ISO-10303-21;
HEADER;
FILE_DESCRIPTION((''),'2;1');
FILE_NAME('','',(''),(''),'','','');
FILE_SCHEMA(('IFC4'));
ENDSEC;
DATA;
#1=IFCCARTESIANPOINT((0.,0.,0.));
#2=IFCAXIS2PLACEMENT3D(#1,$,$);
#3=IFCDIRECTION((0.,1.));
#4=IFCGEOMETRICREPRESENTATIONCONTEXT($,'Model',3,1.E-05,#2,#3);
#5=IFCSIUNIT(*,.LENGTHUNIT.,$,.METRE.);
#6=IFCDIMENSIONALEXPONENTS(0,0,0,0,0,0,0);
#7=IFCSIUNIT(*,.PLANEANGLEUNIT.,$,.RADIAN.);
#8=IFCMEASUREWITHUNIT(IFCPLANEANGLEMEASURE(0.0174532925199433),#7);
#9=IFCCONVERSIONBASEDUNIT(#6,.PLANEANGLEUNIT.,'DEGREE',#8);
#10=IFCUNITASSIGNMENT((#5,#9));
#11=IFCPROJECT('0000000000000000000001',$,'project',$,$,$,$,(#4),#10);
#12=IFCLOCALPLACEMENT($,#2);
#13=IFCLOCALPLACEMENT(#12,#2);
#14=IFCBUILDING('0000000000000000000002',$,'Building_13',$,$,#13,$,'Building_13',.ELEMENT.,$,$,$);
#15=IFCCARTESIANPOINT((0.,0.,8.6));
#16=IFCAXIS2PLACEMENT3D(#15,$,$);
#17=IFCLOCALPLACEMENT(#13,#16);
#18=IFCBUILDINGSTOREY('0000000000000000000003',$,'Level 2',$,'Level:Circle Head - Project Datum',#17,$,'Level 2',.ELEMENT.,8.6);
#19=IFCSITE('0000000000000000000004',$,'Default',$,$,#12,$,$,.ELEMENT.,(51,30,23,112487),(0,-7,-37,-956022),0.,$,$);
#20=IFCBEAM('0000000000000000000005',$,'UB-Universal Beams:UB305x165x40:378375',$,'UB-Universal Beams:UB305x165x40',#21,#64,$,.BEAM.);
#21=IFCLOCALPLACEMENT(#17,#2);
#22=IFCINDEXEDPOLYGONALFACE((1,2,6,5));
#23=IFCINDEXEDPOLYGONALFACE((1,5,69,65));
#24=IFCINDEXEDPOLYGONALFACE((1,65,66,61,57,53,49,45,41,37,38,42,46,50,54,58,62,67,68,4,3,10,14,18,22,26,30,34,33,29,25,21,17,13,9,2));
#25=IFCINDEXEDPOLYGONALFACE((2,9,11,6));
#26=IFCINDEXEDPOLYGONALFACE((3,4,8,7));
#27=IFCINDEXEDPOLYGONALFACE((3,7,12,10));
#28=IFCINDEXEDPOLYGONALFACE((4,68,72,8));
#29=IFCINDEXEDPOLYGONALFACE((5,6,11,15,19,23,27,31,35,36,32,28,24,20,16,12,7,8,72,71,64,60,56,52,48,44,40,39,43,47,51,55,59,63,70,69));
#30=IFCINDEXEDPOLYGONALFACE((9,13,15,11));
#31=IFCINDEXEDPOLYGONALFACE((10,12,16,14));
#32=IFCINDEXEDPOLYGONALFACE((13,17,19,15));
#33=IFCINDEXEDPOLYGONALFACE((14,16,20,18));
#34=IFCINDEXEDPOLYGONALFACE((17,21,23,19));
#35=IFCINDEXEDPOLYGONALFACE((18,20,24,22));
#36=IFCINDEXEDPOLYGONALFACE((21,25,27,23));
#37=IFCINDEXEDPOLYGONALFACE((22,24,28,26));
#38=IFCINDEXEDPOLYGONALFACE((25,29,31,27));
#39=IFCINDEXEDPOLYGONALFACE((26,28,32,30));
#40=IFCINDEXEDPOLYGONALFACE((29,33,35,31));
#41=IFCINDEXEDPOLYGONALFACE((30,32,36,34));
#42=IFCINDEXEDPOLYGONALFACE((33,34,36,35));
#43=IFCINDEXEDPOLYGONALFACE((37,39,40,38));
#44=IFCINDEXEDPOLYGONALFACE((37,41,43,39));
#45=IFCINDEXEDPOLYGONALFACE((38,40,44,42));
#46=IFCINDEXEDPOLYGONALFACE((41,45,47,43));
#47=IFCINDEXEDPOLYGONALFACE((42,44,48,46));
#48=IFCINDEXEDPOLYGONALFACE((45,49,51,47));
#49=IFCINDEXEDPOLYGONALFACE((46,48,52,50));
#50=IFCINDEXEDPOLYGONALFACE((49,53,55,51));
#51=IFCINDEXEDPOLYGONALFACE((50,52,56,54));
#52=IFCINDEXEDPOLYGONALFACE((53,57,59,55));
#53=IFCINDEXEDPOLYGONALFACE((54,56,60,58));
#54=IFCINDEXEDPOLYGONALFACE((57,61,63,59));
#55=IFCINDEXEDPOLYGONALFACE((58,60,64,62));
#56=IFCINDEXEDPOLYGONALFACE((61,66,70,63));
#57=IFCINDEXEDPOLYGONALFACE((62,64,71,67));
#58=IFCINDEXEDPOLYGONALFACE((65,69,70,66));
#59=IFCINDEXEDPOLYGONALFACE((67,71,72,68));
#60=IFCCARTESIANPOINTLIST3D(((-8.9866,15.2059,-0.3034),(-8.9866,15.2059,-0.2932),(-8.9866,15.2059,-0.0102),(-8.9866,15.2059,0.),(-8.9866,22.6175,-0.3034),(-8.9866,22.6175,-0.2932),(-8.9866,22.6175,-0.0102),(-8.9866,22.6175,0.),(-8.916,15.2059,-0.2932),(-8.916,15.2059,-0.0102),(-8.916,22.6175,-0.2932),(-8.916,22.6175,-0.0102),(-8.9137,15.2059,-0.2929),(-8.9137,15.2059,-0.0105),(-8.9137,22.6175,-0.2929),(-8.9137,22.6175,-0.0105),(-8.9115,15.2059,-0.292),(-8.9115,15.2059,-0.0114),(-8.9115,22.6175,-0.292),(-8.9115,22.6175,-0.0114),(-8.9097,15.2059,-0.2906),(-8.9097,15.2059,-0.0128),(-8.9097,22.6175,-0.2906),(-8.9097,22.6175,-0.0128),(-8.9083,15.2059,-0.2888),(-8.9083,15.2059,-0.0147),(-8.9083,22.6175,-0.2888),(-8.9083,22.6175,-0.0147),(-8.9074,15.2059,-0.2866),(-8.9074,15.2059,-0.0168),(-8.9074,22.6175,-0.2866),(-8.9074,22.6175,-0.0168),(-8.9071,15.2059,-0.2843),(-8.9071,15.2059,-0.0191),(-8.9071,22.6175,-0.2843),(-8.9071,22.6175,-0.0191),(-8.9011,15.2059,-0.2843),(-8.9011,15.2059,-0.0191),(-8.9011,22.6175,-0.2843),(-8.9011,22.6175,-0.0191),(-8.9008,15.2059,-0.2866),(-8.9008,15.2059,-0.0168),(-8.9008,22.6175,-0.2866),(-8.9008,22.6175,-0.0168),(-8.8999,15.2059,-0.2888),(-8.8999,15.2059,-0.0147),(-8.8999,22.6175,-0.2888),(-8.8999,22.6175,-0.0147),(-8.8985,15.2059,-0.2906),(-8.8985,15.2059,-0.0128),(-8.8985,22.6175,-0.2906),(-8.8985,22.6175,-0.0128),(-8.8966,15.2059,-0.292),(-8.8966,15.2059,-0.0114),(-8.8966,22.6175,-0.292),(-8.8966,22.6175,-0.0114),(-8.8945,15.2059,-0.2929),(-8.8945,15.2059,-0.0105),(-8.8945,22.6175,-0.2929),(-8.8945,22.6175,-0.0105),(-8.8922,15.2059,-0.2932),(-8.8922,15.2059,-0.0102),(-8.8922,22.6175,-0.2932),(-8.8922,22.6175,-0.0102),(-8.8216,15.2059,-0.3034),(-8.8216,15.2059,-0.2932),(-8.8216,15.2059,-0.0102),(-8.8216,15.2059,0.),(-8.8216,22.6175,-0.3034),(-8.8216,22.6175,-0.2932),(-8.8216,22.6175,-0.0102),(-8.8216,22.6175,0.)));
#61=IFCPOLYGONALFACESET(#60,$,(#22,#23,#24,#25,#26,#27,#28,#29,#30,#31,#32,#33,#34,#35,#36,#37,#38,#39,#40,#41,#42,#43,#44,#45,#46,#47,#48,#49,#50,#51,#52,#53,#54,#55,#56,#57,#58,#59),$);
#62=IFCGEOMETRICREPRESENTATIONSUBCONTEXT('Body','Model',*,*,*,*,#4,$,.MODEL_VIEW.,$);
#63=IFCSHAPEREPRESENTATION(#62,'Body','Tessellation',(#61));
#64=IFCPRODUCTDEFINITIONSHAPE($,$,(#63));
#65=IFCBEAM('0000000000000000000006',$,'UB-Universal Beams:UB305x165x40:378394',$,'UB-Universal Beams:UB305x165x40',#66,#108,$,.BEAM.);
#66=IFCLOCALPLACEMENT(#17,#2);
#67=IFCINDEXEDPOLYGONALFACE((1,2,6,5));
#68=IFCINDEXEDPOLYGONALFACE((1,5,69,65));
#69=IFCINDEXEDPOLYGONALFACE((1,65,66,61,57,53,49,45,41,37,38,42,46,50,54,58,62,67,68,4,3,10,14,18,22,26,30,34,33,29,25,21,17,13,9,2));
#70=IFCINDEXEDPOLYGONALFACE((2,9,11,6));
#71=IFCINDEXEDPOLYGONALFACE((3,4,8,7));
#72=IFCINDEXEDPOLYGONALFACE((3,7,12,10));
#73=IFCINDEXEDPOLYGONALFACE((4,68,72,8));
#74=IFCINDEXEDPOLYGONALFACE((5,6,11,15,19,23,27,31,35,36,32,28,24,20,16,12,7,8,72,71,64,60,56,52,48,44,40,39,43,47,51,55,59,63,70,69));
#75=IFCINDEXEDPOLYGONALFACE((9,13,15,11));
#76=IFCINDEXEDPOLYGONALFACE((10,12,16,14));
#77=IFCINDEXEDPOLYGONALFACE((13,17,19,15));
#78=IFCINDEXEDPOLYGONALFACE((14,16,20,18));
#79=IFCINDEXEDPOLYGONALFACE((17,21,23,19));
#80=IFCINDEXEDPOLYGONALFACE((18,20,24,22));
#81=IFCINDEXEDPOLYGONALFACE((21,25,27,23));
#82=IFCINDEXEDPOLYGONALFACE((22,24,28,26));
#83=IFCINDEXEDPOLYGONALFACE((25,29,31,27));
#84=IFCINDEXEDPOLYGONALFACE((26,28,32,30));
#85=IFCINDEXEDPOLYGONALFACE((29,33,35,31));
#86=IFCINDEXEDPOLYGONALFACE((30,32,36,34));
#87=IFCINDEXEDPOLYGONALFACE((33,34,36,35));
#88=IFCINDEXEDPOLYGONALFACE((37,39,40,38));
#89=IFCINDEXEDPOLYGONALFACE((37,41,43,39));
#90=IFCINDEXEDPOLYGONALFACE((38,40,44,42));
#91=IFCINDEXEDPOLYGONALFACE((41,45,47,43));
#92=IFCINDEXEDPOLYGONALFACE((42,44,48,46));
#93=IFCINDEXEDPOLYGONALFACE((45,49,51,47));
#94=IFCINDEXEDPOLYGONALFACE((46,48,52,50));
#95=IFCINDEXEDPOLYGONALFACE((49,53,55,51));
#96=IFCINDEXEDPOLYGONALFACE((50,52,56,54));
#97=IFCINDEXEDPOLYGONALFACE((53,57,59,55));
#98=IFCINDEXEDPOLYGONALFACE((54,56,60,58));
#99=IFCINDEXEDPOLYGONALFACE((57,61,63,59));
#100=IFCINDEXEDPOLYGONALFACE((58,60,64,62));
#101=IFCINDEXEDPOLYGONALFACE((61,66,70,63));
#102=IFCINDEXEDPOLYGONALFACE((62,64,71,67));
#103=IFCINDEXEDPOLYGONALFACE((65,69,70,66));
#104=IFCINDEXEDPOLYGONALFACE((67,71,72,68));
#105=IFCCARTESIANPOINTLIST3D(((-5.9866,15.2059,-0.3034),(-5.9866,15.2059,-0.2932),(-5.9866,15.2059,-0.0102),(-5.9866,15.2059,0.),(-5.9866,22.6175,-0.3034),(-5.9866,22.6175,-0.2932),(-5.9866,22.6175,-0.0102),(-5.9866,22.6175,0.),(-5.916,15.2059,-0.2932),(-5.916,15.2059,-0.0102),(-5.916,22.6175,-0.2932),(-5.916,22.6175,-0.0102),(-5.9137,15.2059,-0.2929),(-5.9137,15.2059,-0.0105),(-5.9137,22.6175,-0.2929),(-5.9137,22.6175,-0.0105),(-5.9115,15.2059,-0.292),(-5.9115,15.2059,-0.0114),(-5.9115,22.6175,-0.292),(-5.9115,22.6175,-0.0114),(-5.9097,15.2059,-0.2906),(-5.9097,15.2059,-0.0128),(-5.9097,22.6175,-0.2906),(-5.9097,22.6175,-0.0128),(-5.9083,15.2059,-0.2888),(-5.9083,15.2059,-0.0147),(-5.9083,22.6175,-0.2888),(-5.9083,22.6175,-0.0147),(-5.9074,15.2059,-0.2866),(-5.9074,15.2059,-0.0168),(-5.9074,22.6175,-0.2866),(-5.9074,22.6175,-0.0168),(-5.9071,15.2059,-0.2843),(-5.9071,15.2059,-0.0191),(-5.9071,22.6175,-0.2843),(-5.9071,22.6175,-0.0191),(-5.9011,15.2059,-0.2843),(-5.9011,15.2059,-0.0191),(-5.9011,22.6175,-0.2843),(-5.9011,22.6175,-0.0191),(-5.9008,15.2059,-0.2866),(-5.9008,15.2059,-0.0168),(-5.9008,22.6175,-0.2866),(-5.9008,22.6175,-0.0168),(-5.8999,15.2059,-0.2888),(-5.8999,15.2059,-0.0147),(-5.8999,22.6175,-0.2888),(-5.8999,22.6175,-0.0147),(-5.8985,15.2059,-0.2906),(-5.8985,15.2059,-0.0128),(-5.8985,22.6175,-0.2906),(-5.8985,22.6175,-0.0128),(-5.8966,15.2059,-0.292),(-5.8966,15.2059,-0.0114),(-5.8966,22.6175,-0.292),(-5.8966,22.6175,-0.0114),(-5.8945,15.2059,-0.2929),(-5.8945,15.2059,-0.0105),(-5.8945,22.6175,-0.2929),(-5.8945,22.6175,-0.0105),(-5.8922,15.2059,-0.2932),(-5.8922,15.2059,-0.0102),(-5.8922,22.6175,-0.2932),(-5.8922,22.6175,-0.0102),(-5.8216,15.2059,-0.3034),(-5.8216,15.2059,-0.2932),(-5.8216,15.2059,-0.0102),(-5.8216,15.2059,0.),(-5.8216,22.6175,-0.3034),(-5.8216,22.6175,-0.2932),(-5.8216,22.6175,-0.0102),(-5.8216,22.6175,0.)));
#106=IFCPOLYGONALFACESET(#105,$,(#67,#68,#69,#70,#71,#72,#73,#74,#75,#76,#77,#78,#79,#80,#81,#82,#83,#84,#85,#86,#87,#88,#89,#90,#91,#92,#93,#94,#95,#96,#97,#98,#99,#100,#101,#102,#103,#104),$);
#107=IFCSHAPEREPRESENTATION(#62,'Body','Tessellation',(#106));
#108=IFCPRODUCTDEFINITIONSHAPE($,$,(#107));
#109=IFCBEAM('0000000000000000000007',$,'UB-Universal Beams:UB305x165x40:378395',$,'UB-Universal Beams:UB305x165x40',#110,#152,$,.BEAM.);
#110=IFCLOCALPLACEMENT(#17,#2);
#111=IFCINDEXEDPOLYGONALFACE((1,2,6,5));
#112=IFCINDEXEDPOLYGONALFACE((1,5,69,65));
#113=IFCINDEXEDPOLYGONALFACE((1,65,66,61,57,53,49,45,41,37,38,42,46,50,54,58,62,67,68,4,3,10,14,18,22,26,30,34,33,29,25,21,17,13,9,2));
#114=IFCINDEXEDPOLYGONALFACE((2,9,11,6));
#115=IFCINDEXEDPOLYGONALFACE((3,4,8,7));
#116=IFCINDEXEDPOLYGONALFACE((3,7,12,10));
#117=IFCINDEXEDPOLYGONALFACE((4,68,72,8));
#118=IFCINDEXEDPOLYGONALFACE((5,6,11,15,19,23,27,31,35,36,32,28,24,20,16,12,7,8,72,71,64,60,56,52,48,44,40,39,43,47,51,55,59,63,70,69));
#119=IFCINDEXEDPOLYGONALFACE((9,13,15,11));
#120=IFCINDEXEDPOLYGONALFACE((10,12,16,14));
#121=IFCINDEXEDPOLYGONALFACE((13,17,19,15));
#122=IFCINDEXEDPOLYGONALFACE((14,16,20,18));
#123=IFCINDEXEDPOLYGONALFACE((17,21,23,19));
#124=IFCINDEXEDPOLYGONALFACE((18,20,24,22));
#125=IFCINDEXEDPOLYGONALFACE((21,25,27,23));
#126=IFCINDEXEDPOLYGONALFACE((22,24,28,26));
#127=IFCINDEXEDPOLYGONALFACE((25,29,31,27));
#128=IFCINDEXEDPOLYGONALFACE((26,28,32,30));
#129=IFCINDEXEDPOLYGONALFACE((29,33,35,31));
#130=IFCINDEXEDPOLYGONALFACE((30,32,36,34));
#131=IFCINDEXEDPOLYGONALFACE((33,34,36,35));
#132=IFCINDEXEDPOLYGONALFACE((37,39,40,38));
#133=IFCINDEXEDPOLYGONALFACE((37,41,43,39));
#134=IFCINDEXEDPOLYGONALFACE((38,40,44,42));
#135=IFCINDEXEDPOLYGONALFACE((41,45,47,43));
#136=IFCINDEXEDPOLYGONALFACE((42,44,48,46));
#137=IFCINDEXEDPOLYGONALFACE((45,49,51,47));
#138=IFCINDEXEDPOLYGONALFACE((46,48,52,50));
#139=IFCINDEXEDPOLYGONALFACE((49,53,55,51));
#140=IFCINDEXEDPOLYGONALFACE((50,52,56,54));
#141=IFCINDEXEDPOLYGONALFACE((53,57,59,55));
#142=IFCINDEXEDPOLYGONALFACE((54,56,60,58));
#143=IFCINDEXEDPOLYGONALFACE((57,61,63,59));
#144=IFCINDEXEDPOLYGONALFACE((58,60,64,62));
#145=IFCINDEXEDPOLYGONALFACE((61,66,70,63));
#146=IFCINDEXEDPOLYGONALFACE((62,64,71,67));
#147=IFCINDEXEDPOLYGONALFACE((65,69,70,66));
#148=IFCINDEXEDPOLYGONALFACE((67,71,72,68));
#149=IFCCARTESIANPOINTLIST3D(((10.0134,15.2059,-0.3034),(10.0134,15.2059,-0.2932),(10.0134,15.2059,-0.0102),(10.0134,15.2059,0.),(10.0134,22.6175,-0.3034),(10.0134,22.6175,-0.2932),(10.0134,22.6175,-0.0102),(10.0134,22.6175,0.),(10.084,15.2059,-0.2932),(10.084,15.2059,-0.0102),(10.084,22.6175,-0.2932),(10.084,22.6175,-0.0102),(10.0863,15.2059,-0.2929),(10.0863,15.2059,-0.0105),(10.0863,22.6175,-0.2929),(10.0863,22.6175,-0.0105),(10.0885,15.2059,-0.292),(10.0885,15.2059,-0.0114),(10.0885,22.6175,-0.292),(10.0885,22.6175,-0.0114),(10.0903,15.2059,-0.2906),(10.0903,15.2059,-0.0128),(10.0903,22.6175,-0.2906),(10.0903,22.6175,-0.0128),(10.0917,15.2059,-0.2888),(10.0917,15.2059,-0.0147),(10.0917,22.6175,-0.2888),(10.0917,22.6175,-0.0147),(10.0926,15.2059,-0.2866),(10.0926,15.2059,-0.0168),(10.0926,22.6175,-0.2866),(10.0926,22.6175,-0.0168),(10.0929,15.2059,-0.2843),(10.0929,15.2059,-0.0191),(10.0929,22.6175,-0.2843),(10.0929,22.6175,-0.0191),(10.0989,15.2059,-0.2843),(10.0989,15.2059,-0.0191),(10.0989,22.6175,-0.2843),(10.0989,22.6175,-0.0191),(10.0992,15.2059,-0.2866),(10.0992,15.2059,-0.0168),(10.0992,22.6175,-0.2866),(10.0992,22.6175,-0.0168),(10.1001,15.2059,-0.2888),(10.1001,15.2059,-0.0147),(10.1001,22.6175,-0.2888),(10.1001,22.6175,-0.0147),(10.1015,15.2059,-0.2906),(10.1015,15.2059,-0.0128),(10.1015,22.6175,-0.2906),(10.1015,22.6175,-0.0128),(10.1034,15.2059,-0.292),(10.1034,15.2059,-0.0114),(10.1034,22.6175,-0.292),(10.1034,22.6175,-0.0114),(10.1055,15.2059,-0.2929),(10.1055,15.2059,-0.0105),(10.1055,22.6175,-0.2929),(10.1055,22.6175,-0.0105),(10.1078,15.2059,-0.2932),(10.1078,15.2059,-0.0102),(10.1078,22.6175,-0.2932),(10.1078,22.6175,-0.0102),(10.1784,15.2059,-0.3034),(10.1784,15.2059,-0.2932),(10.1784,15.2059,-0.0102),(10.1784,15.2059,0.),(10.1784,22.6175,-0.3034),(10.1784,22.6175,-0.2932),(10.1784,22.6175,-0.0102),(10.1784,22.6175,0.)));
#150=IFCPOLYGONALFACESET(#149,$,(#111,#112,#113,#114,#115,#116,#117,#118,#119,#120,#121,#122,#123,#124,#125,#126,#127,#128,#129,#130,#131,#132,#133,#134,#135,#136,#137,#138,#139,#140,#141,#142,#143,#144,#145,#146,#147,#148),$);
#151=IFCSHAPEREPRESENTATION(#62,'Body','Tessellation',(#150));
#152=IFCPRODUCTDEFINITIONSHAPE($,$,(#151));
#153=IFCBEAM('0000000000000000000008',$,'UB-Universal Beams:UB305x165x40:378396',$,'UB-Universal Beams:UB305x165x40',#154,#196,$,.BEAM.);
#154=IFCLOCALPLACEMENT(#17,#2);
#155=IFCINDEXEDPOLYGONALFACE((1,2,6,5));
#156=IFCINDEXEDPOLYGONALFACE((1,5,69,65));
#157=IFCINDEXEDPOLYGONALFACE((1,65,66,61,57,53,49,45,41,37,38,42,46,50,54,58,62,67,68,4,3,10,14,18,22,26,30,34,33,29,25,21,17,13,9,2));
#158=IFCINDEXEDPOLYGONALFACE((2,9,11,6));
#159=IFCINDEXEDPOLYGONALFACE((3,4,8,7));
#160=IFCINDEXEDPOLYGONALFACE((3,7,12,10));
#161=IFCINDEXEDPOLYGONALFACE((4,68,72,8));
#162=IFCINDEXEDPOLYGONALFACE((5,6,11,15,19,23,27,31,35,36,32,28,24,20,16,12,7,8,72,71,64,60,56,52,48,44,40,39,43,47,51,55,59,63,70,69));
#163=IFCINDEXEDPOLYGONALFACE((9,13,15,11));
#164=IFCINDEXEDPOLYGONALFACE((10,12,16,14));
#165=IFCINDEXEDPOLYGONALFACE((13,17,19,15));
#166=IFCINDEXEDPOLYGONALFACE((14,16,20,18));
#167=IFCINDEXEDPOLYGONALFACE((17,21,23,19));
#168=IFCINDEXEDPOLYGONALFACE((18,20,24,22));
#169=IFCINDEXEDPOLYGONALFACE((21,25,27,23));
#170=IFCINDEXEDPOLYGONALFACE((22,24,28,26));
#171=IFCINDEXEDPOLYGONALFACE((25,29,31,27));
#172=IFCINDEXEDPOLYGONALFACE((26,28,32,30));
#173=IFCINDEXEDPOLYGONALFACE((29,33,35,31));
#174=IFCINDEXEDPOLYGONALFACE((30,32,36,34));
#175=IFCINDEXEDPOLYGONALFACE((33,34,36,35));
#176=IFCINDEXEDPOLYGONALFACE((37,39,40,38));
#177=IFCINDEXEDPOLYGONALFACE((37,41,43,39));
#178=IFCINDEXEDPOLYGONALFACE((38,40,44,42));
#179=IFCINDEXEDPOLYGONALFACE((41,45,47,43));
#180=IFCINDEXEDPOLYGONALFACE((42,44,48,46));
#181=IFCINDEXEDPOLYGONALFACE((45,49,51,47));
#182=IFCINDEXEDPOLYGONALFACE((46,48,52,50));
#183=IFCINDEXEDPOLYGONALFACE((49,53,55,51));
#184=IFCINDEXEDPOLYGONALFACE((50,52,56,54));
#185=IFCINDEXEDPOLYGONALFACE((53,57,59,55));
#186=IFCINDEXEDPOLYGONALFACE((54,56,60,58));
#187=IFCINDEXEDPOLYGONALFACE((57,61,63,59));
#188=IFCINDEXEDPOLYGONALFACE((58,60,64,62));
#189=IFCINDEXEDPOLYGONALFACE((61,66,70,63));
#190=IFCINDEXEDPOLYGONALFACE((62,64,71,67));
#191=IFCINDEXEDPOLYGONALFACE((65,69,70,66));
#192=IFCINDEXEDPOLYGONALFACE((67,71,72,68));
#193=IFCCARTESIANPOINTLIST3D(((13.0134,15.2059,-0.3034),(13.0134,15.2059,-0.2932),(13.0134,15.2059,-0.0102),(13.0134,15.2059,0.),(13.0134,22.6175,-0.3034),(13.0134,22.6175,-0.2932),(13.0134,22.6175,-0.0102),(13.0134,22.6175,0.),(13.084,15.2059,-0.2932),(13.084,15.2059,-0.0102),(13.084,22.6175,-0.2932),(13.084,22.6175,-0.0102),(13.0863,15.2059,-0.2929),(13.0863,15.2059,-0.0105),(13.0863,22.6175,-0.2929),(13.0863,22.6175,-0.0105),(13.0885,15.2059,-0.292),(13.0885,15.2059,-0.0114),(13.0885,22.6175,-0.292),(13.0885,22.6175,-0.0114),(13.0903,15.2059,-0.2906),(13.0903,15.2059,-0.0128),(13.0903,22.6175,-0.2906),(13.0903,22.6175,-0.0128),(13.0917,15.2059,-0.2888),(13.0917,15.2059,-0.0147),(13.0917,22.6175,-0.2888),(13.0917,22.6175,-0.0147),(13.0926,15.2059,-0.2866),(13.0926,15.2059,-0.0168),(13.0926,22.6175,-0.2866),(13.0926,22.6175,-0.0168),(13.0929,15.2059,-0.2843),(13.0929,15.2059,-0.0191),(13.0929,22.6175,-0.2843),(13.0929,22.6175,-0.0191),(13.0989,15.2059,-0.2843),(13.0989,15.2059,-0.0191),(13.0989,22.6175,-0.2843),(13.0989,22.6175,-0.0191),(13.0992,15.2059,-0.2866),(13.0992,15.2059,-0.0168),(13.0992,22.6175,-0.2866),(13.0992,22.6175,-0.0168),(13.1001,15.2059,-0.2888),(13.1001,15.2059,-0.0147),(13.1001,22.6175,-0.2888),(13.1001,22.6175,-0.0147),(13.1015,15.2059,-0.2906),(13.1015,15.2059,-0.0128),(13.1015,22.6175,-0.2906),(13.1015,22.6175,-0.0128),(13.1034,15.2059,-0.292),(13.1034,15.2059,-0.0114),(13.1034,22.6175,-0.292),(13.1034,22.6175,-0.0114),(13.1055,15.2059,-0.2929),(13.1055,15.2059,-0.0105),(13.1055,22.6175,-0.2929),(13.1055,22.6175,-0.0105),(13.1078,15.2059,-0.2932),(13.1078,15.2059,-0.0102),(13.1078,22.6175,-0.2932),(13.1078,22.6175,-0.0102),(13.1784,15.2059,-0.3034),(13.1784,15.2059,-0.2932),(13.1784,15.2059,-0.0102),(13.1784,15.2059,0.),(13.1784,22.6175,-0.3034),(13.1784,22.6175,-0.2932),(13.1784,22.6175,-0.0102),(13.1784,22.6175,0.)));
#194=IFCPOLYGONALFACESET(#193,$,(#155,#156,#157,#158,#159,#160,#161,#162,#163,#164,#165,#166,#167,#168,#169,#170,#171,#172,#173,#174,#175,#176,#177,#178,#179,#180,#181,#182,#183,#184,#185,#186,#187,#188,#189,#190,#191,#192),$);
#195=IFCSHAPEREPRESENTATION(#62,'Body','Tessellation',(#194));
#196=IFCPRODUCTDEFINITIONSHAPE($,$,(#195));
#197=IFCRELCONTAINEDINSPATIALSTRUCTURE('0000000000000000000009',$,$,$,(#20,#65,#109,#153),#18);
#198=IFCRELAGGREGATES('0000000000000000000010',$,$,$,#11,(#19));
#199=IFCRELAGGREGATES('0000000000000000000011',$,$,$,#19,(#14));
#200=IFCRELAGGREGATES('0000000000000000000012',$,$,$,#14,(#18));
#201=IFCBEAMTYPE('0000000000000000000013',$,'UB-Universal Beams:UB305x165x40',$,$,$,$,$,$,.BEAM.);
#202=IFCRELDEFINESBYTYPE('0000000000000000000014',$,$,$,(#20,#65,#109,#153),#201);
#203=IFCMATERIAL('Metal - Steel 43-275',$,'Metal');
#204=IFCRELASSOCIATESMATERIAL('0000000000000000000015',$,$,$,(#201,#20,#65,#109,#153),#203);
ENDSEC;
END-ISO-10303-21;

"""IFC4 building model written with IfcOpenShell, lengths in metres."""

from ifc_helpers import new_model, entity, si_unit, converted_unit, direction, frame, origin, place, context, subcontext, project, spatial, line, arc, indexed_curve, outline, extrude, source, transform, mapped, material, type_object, type_shapes, element, save


model = new_model("IFC4")

# Units and contexts
model_context = context("Model", 3, precision=1e-05, world=origin(), true_north=direction((0.0, 1.0)))
body_context = subcontext(model_context, "Body", "Model", "MODEL_VIEW")
ifc_project = project(units=[si_unit("LENGTHUNIT", "METRE"), converted_unit("PLANEANGLEUNIT", "DEGREE", entity("IfcPlaneAngleMeasure", 0.0174532925199433), si_unit("PLANEANGLEUNIT", "RADIAN"), dimensions=[0, 0, 0, 0, 0, 0, 0])], contexts=[model_context])

# Site, building, storey
site_placement = place(None, origin())
site = spatial("IfcSite", under=ifc_project, at=site_placement, Name="Default", CompositionType="ELEMENT", RefLatitude=(51, 30, 23, 112487), RefLongitude=(0, -7, -37, -956022), RefElevation=0.0)
building_placement = place(site_placement, origin())
building = spatial("IfcBuilding", under=site, at=building_placement, Name="Building_13", LongName="Building_13", CompositionType="ELEMENT")
storey_placement = place(building_placement, frame((0.0, 0.0, 8.6)))
storey = spatial("IfcBuildingStorey", under=building, at=storey_placement, Name="Level 2", ObjectType="Level:Circle Head - Project Datum", LongName="Level 2", CompositionType="ELEMENT", Elevation=8.6)

# Beams
ifc_material_1 = material(Name="Metal - Steel 43-275", Category="Metal")
beam_type_1 = type_object("IfcBeamType", Name="UB-Universal Beams:UB305x165x40", PredefinedType="BEAM", material=ifc_material_1)
shared_shape_1 = source(origin(), body_context, "Body", "SweptSolid", [
    extrude(outline(indexed_curve([(-0.0825, -0.1415), (-0.0825, -0.1517), (0.0825, -0.1517), (0.0825, -0.1415), (0.0119, -0.1415), (0.0056, -0.1389), (0.003, -0.1326), (0.003, 0.1326), (0.0056, 0.1389), (0.0119, 0.1415), (0.0825, 0.1415), (0.0825, 0.1517), (-0.0825, 0.1517), (-0.0825, 0.1415), (-0.0119, 0.1415), (-0.0056, 0.1389), (-0.003, 0.1326), (-0.003, -0.1326), (-0.0056, -0.1389), (-0.0119, -0.1415)], segments=[line(1, 2, 3, 4, 5), arc(5, 6, 7), line(7, 8), arc(8, 9, 10), line(10, 11, 12, 13, 14, 15), arc(15, 16, 17), line(17, 18), arc(18, 19, 20), line(20, 1)], self_intersect=False)), frame((-3.7058, 0.0, 0.0), z_axis=(-1.0, 0.0, 0.0), x_axis=(0.0, -1.0, 0.0)), (0.0, 0.0, -1.0), 7.4116),
])
type_shapes(beam_type_1, [shared_shape_1])
for number, where, z_axis, x_axis, name in (
    (1, (-8.9041, 18.9117, -0.1517), (0.0, 0.0, 1.0), (0.0, -1.0, 0.0), "UB-Universal Beams:UB305x165x40:378375"),
    (2, (-5.9041, 18.9117, -0.1517), (0.0, 0.0, 1.0), (0.0, -1.0, 0.0), "UB-Universal Beams:UB305x165x40:378394"),
    (3, (10.0959, 18.9117, -0.1517), (0.0, 0.0, 1.0), (0.0, -1.0, 0.0), "UB-Universal Beams:UB305x165x40:378395"),
    (4, (13.0959, 18.9117, -0.1517), (0.0, 0.0, 1.0), (0.0, -1.0, 0.0), "UB-Universal Beams:UB305x165x40:378396"),
):
    element("IfcBeam", number, at=place(storey_placement, frame(where, z_axis=z_axis, x_axis=x_axis)), inside=storey, type_object=beam_type_1, material=ifc_material_1, Name=name, ObjectType="UB-Universal Beams:UB305x165x40", PredefinedType="BEAM", context=body_context, shape_type="MappedRepresentation", body=[
        mapped(shared_shape_1, transform((0.0, 0.0, 0.0), scale=1.0)),
    ])

save(model, "model.ifc")
